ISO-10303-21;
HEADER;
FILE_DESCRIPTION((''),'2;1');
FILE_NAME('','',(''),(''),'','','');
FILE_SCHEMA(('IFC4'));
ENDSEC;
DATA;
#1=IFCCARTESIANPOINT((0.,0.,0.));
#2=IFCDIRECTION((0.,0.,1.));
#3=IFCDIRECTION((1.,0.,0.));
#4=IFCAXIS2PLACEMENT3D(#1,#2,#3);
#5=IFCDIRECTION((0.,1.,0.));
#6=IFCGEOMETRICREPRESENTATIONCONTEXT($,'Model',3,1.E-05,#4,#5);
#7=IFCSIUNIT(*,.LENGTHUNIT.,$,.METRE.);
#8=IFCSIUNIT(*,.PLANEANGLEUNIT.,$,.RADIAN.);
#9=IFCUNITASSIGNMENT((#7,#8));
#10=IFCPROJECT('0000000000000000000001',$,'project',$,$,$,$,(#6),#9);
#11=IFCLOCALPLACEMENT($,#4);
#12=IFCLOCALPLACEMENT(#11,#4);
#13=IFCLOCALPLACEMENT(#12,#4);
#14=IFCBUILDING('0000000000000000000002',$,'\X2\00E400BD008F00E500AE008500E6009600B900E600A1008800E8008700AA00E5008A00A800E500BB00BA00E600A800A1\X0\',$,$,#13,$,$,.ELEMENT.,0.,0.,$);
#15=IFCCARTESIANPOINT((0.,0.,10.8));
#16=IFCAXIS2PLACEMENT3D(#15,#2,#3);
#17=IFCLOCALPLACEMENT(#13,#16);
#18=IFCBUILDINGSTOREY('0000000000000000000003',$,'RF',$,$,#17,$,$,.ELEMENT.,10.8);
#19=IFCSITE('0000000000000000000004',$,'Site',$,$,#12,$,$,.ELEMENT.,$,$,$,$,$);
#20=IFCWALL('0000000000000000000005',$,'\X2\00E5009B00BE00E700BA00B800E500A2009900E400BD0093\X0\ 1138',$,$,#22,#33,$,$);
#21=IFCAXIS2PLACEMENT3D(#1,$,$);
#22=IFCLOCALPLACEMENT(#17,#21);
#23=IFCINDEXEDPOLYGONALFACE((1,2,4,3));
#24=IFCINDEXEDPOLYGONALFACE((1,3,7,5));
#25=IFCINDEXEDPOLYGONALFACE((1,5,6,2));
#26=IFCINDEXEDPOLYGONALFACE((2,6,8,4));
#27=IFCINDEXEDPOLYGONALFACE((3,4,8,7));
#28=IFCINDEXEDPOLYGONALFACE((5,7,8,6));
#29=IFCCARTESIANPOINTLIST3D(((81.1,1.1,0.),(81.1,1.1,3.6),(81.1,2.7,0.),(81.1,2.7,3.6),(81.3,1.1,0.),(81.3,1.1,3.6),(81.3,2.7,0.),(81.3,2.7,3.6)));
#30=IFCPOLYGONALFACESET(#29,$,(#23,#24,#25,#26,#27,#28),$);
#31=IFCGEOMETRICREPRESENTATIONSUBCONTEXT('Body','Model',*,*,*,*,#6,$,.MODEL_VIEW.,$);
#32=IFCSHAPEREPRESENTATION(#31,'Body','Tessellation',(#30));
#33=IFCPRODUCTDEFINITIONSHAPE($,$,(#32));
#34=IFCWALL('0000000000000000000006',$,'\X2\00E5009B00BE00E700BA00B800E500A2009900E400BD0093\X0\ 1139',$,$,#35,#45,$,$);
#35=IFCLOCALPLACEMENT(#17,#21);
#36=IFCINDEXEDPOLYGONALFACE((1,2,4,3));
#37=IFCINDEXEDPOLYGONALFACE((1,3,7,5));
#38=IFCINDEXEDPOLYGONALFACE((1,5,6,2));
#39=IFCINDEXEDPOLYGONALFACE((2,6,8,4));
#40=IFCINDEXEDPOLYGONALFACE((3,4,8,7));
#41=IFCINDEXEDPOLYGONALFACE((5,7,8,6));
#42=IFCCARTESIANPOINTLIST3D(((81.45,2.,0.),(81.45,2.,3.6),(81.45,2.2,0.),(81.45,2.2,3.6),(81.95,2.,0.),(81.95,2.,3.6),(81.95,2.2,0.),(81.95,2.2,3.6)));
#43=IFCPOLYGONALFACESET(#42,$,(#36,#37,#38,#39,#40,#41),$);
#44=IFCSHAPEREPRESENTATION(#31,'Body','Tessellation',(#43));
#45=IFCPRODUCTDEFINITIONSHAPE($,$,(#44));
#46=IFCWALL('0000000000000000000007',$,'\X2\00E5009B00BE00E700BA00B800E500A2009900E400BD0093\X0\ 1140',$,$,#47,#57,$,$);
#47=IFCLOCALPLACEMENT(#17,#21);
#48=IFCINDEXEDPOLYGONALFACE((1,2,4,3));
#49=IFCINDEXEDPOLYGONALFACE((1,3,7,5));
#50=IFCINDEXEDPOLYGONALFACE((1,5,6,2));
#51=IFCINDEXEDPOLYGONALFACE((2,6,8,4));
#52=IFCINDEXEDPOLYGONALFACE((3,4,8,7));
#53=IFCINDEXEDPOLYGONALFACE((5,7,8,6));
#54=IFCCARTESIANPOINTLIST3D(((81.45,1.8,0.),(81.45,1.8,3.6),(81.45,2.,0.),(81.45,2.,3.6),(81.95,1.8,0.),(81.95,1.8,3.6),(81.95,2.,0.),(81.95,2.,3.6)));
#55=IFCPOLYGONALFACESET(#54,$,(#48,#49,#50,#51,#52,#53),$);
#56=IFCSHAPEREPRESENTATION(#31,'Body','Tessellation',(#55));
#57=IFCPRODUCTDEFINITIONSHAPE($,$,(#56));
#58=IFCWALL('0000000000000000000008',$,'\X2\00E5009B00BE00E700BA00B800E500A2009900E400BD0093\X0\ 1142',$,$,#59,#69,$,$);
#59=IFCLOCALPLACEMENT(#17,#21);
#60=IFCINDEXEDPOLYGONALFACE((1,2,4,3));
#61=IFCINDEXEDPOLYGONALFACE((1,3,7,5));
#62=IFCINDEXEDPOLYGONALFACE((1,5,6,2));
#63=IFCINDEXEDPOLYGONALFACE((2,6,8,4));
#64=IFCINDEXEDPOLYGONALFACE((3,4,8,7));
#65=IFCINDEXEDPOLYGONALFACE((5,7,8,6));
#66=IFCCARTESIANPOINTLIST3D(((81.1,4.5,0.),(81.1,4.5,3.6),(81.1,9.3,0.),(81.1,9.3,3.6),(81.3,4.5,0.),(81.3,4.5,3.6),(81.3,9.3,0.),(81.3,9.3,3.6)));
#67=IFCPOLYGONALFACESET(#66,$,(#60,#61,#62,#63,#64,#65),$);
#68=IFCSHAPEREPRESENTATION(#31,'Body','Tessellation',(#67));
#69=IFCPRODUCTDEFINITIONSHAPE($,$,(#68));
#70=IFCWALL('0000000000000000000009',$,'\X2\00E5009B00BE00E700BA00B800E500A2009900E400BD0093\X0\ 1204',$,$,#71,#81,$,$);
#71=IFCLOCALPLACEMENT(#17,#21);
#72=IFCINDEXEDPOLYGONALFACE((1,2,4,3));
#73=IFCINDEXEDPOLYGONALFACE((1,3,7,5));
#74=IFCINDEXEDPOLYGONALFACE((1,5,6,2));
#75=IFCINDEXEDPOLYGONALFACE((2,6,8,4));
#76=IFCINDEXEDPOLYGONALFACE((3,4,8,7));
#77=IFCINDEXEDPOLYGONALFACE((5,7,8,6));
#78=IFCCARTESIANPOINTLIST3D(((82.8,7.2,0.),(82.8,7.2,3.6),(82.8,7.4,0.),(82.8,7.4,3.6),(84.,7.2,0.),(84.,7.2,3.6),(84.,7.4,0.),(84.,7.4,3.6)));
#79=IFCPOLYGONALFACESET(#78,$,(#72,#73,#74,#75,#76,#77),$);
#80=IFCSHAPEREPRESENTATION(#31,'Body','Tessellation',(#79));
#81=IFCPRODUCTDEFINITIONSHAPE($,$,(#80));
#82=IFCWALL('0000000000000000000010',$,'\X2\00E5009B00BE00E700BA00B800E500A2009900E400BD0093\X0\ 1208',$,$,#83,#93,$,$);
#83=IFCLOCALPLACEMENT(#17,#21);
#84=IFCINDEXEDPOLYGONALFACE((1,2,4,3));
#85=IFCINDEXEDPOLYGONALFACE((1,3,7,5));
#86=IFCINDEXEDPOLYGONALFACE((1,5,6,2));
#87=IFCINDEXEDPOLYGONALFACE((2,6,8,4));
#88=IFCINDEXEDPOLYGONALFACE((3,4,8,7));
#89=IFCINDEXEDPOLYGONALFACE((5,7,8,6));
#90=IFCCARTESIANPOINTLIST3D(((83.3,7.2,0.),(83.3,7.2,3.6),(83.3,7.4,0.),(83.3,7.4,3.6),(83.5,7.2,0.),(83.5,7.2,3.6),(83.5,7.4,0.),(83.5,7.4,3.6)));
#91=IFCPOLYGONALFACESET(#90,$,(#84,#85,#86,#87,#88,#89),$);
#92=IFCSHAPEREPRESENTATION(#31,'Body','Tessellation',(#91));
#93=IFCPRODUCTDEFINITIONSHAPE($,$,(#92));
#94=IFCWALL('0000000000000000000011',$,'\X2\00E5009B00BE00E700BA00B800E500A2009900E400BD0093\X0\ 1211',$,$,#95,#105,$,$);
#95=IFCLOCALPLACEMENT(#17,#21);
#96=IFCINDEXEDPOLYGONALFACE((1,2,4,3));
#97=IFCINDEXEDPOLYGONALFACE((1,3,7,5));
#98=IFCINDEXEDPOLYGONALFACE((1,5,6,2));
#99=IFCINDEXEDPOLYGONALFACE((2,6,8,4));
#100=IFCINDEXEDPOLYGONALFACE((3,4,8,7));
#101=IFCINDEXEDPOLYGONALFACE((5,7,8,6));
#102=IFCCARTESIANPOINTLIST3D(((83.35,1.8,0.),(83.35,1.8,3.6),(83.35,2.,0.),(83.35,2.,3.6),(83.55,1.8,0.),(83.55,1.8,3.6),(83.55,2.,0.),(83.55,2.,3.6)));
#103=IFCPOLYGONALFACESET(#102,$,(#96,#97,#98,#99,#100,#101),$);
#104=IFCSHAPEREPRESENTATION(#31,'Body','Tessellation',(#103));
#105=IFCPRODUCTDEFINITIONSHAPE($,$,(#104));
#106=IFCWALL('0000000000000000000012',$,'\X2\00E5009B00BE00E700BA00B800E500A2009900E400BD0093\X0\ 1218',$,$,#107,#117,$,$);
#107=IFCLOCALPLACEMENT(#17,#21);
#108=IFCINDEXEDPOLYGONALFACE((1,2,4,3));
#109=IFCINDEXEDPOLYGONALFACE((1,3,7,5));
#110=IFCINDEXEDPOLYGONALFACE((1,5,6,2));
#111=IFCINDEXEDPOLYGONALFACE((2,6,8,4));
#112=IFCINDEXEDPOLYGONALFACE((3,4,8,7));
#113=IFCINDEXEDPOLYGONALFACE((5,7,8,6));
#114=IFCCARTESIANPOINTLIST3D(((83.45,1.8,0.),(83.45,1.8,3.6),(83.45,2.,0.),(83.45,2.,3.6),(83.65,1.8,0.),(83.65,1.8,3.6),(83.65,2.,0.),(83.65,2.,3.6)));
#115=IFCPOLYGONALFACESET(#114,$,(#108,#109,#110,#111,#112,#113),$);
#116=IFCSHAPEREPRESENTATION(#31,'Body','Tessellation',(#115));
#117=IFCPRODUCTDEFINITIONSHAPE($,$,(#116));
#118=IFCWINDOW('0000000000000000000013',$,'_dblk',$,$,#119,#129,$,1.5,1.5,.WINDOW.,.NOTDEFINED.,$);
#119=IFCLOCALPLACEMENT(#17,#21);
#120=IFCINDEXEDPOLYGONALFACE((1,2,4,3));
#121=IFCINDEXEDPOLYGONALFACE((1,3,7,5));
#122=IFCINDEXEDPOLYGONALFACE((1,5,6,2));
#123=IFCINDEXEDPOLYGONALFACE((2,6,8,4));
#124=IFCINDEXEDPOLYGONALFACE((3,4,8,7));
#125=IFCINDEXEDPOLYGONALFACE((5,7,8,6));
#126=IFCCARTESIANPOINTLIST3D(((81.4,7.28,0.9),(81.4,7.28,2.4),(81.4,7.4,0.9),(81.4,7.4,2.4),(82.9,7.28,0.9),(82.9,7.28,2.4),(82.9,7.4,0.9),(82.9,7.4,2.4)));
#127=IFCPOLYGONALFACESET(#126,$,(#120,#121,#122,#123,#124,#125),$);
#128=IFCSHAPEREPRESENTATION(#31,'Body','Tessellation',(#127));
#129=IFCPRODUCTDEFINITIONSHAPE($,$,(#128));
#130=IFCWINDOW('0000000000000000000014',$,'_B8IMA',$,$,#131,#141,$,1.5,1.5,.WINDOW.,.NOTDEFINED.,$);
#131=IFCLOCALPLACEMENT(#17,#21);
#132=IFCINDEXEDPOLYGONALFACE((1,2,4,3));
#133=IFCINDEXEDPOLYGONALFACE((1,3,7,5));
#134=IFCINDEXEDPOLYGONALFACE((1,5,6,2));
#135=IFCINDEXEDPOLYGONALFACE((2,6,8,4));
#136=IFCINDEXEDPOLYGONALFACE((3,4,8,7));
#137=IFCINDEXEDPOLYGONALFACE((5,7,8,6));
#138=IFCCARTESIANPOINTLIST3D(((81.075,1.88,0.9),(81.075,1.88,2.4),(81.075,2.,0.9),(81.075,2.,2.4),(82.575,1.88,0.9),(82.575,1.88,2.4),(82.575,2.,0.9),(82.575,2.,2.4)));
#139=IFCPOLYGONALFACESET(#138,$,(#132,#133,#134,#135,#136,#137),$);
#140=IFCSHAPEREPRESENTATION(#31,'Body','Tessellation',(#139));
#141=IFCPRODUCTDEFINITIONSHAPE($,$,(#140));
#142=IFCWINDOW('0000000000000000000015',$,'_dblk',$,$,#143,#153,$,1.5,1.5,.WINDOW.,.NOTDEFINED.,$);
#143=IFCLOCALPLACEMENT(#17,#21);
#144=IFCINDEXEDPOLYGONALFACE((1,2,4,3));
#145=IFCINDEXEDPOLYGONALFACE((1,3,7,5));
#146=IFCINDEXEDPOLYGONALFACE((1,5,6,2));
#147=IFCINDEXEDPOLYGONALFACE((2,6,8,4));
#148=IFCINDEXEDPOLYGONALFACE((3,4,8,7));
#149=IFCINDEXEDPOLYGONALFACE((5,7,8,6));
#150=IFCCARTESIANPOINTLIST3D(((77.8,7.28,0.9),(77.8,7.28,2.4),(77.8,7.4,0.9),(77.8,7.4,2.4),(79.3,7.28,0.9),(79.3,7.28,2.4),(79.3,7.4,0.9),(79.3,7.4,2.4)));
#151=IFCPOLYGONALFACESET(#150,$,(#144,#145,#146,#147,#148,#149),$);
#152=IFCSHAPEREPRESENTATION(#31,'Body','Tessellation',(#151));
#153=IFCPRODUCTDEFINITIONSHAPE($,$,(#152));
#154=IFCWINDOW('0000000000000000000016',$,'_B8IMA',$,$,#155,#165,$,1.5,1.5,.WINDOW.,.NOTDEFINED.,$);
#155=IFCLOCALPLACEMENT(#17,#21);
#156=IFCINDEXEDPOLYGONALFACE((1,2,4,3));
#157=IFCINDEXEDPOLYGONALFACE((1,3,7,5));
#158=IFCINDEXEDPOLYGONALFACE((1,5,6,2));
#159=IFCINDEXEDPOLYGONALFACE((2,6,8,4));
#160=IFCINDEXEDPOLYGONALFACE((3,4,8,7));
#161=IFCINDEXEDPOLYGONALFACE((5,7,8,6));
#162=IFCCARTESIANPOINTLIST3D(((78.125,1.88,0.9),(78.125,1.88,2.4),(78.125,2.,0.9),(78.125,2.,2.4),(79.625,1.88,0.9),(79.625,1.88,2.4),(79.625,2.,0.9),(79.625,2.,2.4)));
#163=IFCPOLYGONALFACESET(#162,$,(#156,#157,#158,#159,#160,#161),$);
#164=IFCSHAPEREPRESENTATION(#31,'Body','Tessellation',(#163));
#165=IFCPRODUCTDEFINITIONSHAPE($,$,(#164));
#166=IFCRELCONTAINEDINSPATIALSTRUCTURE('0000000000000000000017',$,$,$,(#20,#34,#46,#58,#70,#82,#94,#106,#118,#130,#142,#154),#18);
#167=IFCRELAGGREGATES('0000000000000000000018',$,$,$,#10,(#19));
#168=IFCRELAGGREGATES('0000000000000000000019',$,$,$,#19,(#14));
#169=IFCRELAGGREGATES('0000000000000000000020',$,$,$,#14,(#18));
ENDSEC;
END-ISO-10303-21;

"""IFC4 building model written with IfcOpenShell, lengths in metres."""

from ifc_helpers import new_model, si_unit, direction, frame, frame_2d, origin_with_axes, place, context, subcontext, project, spatial, rectangle, extrude, element, save


model = new_model("IFC4")

# Units and contexts
model_context = context("Model", 3, precision=1e-05, world=origin_with_axes(), true_north=direction((0.0, 1.0, 0.0)))
body_context = subcontext(model_context, "Body", "Model", "MODEL_VIEW")
ifc_project = project(units=[si_unit("LENGTHUNIT", "METRE"), si_unit("PLANEANGLEUNIT", "RADIAN")], contexts=[model_context])

# Site, building, storey
placement = place(None, origin_with_axes())
site_placement = place(placement, origin_with_axes())
site = spatial("IfcSite", under=ifc_project, at=site_placement, Name="Site", CompositionType="ELEMENT")
building_placement = place(site_placement, origin_with_axes())
building = spatial("IfcBuilding", under=site, at=building_placement, Name="ä½\u008få®\u0085æ\u0096¹æ¡\u0088è\u0087ªå\u008a¨å»ºæ¨¡", CompositionType="ELEMENT", ElevationOfRefHeight=0.0, ElevationOfTerrain=0.0)
storey_placement = place(building_placement, frame((0.0, 0.0, 10.8), z_axis=(0.0, 0.0, 1.0), x_axis=(1.0, 0.0, 0.0)))
storey = spatial("IfcBuildingStorey", under=building, at=storey_placement, Name="RF", CompositionType="ELEMENT", Elevation=10.8)

# Walls
wall_1_placement = place(storey_placement, frame((81.2, 1.9, 0.0), z_axis=(0.0, 0.0, 1.0), x_axis=(0.0, -1.0, 0.0)))
element("IfcWall", 1, at=wall_1_placement, inside=storey, Name="å\u009b¾çº¸å¢\u0099ä½\u0093 1138", context=body_context, shape_type="SweptSolid", body=[
    extrude(rectangle(XDim=1.6, YDim=0.2, at=frame_2d((0.0, 0.0), x_axis=(1.0, 0.0, 0.0))), frame((0.0, 0.0, 0.0), z_axis=(0.0, 0.0, 1.0)), (0.0, 0.0, 1.0), 3.6),
])
for number, where, z_axis, x_axis, name in (
    (2, (81.7, 2.1, 0.0), (0.0, 0.0, 1.0), (-1.0, 0.0, 0.0), "å\u009b¾çº¸å¢\u0099ä½\u0093 1139"),
    (3, (81.7, 1.9, 0.0), (0.0, 0.0, 1.0), (-1.0, 0.0, 0.0), "å\u009b¾çº¸å¢\u0099ä½\u0093 1140"),
):
    element("IfcWall", number, at=place(storey_placement, frame(where, z_axis=z_axis, x_axis=x_axis)), inside=storey, Name=name, context=body_context, shape_type="SweptSolid", body=[
        extrude(rectangle(XDim=0.5, YDim=0.2, at=frame_2d((0.0, 0.0), x_axis=(1.0, 0.0, 0.0))), frame((0.0, 0.0, 0.0), z_axis=(0.0, 0.0, 1.0)), (0.0, 0.0, 1.0), 3.6),
    ])
wall_2_placement = place(storey_placement, frame((81.2, 6.9, 0.0), z_axis=(0.0, 0.0, 1.0), x_axis=(0.0, -1.0, 0.0)))
element("IfcWall", 4, at=wall_2_placement, inside=storey, Name="å\u009b¾çº¸å¢\u0099ä½\u0093 1142", context=body_context, shape_type="SweptSolid", body=[
    extrude(rectangle(XDim=4.8, YDim=0.2, at=frame_2d((0.0, 0.0), x_axis=(1.0, 0.0, 0.0))), frame((0.0, 0.0, 0.0), z_axis=(0.0, 0.0, 1.0)), (0.0, 0.0, 1.0), 3.6),
])
wall_3_placement = place(storey_placement, frame((83.4, 7.3, 0.0), z_axis=(0.0, 0.0, 1.0), x_axis=(1.0, 0.0, 0.0)))
element("IfcWall", 5, at=wall_3_placement, inside=storey, Name="å\u009b¾çº¸å¢\u0099ä½\u0093 1204", context=body_context, shape_type="SweptSolid", body=[
    extrude(rectangle(XDim=1.2, YDim=0.2, at=frame_2d((0.0, 0.0), x_axis=(1.0, 0.0, 0.0))), frame((0.0, 0.0, 0.0), z_axis=(0.0, 0.0, 1.0)), (0.0, 0.0, 1.0), 3.6),
])
for number, where, z_axis, x_axis, name in (
    (6, (83.4, 7.3, 0.0), (0.0, 0.0, 1.0), (0.0, 1.0, 0.0), "å\u009b¾çº¸å¢\u0099ä½\u0093 1208"),
    (7, (83.45, 1.9, 0.0), (0.0, 0.0, 1.0), (0.0, 1.0, 0.0), "å\u009b¾çº¸å¢\u0099ä½\u0093 1211"),
    (8, (83.55, 1.9, 0.0), (0.0, 0.0, 1.0), (0.0, -1.0, 0.0), "å\u009b¾çº¸å¢\u0099ä½\u0093 1218"),
):
    element("IfcWall", number, at=place(storey_placement, frame(where, z_axis=z_axis, x_axis=x_axis)), inside=storey, Name=name, context=body_context, shape_type="SweptSolid", body=[
        extrude(rectangle(XDim=0.2, YDim=0.2, at=frame_2d((0.0, 0.0), x_axis=(1.0, 0.0, 0.0))), frame((0.0, 0.0, 0.0), z_axis=(0.0, 0.0, 1.0)), (0.0, 0.0, 1.0), 3.6),
    ])

# Windows
for number, where, z_axis, x_axis, name in (
    (9, (82.15, 7.34, 0.9), (0.0, 0.0, 1.0), (1.0, 0.0, 0.0), "_dblk"),
    (10, (81.825, 1.94, 0.9), (0.0, 0.0, 1.0), (1.0, 0.0, 0.0), "_B8IMA"),
    (11, (78.55, 7.34, 0.9), (0.0, 0.0, 1.0), (1.0, 0.0, 0.0), "_dblk"),
    (12, (78.875, 1.94, 0.9), (0.0, 0.0, 1.0), (1.0, 0.0, 0.0), "_B8IMA"),
):
    element("IfcWindow", number, at=place(storey_placement, frame(where, z_axis=z_axis, x_axis=x_axis)), inside=storey, Name=name, OverallHeight=1.5, OverallWidth=1.5, PartitioningType="NOTDEFINED", PredefinedType="WINDOW", context=body_context, shape_type="SweptSolid", body=[
        extrude(rectangle(XDim=1.5, YDim=0.12, at=frame_2d((0.0, 0.0), x_axis=(1.0, 0.0, 0.0))), frame((0.0, 0.0, 0.0), z_axis=(0.0, 0.0, 1.0)), (0.0, 0.0, 1.0), 1.5),
    ])

save(model, "model.ifc")
